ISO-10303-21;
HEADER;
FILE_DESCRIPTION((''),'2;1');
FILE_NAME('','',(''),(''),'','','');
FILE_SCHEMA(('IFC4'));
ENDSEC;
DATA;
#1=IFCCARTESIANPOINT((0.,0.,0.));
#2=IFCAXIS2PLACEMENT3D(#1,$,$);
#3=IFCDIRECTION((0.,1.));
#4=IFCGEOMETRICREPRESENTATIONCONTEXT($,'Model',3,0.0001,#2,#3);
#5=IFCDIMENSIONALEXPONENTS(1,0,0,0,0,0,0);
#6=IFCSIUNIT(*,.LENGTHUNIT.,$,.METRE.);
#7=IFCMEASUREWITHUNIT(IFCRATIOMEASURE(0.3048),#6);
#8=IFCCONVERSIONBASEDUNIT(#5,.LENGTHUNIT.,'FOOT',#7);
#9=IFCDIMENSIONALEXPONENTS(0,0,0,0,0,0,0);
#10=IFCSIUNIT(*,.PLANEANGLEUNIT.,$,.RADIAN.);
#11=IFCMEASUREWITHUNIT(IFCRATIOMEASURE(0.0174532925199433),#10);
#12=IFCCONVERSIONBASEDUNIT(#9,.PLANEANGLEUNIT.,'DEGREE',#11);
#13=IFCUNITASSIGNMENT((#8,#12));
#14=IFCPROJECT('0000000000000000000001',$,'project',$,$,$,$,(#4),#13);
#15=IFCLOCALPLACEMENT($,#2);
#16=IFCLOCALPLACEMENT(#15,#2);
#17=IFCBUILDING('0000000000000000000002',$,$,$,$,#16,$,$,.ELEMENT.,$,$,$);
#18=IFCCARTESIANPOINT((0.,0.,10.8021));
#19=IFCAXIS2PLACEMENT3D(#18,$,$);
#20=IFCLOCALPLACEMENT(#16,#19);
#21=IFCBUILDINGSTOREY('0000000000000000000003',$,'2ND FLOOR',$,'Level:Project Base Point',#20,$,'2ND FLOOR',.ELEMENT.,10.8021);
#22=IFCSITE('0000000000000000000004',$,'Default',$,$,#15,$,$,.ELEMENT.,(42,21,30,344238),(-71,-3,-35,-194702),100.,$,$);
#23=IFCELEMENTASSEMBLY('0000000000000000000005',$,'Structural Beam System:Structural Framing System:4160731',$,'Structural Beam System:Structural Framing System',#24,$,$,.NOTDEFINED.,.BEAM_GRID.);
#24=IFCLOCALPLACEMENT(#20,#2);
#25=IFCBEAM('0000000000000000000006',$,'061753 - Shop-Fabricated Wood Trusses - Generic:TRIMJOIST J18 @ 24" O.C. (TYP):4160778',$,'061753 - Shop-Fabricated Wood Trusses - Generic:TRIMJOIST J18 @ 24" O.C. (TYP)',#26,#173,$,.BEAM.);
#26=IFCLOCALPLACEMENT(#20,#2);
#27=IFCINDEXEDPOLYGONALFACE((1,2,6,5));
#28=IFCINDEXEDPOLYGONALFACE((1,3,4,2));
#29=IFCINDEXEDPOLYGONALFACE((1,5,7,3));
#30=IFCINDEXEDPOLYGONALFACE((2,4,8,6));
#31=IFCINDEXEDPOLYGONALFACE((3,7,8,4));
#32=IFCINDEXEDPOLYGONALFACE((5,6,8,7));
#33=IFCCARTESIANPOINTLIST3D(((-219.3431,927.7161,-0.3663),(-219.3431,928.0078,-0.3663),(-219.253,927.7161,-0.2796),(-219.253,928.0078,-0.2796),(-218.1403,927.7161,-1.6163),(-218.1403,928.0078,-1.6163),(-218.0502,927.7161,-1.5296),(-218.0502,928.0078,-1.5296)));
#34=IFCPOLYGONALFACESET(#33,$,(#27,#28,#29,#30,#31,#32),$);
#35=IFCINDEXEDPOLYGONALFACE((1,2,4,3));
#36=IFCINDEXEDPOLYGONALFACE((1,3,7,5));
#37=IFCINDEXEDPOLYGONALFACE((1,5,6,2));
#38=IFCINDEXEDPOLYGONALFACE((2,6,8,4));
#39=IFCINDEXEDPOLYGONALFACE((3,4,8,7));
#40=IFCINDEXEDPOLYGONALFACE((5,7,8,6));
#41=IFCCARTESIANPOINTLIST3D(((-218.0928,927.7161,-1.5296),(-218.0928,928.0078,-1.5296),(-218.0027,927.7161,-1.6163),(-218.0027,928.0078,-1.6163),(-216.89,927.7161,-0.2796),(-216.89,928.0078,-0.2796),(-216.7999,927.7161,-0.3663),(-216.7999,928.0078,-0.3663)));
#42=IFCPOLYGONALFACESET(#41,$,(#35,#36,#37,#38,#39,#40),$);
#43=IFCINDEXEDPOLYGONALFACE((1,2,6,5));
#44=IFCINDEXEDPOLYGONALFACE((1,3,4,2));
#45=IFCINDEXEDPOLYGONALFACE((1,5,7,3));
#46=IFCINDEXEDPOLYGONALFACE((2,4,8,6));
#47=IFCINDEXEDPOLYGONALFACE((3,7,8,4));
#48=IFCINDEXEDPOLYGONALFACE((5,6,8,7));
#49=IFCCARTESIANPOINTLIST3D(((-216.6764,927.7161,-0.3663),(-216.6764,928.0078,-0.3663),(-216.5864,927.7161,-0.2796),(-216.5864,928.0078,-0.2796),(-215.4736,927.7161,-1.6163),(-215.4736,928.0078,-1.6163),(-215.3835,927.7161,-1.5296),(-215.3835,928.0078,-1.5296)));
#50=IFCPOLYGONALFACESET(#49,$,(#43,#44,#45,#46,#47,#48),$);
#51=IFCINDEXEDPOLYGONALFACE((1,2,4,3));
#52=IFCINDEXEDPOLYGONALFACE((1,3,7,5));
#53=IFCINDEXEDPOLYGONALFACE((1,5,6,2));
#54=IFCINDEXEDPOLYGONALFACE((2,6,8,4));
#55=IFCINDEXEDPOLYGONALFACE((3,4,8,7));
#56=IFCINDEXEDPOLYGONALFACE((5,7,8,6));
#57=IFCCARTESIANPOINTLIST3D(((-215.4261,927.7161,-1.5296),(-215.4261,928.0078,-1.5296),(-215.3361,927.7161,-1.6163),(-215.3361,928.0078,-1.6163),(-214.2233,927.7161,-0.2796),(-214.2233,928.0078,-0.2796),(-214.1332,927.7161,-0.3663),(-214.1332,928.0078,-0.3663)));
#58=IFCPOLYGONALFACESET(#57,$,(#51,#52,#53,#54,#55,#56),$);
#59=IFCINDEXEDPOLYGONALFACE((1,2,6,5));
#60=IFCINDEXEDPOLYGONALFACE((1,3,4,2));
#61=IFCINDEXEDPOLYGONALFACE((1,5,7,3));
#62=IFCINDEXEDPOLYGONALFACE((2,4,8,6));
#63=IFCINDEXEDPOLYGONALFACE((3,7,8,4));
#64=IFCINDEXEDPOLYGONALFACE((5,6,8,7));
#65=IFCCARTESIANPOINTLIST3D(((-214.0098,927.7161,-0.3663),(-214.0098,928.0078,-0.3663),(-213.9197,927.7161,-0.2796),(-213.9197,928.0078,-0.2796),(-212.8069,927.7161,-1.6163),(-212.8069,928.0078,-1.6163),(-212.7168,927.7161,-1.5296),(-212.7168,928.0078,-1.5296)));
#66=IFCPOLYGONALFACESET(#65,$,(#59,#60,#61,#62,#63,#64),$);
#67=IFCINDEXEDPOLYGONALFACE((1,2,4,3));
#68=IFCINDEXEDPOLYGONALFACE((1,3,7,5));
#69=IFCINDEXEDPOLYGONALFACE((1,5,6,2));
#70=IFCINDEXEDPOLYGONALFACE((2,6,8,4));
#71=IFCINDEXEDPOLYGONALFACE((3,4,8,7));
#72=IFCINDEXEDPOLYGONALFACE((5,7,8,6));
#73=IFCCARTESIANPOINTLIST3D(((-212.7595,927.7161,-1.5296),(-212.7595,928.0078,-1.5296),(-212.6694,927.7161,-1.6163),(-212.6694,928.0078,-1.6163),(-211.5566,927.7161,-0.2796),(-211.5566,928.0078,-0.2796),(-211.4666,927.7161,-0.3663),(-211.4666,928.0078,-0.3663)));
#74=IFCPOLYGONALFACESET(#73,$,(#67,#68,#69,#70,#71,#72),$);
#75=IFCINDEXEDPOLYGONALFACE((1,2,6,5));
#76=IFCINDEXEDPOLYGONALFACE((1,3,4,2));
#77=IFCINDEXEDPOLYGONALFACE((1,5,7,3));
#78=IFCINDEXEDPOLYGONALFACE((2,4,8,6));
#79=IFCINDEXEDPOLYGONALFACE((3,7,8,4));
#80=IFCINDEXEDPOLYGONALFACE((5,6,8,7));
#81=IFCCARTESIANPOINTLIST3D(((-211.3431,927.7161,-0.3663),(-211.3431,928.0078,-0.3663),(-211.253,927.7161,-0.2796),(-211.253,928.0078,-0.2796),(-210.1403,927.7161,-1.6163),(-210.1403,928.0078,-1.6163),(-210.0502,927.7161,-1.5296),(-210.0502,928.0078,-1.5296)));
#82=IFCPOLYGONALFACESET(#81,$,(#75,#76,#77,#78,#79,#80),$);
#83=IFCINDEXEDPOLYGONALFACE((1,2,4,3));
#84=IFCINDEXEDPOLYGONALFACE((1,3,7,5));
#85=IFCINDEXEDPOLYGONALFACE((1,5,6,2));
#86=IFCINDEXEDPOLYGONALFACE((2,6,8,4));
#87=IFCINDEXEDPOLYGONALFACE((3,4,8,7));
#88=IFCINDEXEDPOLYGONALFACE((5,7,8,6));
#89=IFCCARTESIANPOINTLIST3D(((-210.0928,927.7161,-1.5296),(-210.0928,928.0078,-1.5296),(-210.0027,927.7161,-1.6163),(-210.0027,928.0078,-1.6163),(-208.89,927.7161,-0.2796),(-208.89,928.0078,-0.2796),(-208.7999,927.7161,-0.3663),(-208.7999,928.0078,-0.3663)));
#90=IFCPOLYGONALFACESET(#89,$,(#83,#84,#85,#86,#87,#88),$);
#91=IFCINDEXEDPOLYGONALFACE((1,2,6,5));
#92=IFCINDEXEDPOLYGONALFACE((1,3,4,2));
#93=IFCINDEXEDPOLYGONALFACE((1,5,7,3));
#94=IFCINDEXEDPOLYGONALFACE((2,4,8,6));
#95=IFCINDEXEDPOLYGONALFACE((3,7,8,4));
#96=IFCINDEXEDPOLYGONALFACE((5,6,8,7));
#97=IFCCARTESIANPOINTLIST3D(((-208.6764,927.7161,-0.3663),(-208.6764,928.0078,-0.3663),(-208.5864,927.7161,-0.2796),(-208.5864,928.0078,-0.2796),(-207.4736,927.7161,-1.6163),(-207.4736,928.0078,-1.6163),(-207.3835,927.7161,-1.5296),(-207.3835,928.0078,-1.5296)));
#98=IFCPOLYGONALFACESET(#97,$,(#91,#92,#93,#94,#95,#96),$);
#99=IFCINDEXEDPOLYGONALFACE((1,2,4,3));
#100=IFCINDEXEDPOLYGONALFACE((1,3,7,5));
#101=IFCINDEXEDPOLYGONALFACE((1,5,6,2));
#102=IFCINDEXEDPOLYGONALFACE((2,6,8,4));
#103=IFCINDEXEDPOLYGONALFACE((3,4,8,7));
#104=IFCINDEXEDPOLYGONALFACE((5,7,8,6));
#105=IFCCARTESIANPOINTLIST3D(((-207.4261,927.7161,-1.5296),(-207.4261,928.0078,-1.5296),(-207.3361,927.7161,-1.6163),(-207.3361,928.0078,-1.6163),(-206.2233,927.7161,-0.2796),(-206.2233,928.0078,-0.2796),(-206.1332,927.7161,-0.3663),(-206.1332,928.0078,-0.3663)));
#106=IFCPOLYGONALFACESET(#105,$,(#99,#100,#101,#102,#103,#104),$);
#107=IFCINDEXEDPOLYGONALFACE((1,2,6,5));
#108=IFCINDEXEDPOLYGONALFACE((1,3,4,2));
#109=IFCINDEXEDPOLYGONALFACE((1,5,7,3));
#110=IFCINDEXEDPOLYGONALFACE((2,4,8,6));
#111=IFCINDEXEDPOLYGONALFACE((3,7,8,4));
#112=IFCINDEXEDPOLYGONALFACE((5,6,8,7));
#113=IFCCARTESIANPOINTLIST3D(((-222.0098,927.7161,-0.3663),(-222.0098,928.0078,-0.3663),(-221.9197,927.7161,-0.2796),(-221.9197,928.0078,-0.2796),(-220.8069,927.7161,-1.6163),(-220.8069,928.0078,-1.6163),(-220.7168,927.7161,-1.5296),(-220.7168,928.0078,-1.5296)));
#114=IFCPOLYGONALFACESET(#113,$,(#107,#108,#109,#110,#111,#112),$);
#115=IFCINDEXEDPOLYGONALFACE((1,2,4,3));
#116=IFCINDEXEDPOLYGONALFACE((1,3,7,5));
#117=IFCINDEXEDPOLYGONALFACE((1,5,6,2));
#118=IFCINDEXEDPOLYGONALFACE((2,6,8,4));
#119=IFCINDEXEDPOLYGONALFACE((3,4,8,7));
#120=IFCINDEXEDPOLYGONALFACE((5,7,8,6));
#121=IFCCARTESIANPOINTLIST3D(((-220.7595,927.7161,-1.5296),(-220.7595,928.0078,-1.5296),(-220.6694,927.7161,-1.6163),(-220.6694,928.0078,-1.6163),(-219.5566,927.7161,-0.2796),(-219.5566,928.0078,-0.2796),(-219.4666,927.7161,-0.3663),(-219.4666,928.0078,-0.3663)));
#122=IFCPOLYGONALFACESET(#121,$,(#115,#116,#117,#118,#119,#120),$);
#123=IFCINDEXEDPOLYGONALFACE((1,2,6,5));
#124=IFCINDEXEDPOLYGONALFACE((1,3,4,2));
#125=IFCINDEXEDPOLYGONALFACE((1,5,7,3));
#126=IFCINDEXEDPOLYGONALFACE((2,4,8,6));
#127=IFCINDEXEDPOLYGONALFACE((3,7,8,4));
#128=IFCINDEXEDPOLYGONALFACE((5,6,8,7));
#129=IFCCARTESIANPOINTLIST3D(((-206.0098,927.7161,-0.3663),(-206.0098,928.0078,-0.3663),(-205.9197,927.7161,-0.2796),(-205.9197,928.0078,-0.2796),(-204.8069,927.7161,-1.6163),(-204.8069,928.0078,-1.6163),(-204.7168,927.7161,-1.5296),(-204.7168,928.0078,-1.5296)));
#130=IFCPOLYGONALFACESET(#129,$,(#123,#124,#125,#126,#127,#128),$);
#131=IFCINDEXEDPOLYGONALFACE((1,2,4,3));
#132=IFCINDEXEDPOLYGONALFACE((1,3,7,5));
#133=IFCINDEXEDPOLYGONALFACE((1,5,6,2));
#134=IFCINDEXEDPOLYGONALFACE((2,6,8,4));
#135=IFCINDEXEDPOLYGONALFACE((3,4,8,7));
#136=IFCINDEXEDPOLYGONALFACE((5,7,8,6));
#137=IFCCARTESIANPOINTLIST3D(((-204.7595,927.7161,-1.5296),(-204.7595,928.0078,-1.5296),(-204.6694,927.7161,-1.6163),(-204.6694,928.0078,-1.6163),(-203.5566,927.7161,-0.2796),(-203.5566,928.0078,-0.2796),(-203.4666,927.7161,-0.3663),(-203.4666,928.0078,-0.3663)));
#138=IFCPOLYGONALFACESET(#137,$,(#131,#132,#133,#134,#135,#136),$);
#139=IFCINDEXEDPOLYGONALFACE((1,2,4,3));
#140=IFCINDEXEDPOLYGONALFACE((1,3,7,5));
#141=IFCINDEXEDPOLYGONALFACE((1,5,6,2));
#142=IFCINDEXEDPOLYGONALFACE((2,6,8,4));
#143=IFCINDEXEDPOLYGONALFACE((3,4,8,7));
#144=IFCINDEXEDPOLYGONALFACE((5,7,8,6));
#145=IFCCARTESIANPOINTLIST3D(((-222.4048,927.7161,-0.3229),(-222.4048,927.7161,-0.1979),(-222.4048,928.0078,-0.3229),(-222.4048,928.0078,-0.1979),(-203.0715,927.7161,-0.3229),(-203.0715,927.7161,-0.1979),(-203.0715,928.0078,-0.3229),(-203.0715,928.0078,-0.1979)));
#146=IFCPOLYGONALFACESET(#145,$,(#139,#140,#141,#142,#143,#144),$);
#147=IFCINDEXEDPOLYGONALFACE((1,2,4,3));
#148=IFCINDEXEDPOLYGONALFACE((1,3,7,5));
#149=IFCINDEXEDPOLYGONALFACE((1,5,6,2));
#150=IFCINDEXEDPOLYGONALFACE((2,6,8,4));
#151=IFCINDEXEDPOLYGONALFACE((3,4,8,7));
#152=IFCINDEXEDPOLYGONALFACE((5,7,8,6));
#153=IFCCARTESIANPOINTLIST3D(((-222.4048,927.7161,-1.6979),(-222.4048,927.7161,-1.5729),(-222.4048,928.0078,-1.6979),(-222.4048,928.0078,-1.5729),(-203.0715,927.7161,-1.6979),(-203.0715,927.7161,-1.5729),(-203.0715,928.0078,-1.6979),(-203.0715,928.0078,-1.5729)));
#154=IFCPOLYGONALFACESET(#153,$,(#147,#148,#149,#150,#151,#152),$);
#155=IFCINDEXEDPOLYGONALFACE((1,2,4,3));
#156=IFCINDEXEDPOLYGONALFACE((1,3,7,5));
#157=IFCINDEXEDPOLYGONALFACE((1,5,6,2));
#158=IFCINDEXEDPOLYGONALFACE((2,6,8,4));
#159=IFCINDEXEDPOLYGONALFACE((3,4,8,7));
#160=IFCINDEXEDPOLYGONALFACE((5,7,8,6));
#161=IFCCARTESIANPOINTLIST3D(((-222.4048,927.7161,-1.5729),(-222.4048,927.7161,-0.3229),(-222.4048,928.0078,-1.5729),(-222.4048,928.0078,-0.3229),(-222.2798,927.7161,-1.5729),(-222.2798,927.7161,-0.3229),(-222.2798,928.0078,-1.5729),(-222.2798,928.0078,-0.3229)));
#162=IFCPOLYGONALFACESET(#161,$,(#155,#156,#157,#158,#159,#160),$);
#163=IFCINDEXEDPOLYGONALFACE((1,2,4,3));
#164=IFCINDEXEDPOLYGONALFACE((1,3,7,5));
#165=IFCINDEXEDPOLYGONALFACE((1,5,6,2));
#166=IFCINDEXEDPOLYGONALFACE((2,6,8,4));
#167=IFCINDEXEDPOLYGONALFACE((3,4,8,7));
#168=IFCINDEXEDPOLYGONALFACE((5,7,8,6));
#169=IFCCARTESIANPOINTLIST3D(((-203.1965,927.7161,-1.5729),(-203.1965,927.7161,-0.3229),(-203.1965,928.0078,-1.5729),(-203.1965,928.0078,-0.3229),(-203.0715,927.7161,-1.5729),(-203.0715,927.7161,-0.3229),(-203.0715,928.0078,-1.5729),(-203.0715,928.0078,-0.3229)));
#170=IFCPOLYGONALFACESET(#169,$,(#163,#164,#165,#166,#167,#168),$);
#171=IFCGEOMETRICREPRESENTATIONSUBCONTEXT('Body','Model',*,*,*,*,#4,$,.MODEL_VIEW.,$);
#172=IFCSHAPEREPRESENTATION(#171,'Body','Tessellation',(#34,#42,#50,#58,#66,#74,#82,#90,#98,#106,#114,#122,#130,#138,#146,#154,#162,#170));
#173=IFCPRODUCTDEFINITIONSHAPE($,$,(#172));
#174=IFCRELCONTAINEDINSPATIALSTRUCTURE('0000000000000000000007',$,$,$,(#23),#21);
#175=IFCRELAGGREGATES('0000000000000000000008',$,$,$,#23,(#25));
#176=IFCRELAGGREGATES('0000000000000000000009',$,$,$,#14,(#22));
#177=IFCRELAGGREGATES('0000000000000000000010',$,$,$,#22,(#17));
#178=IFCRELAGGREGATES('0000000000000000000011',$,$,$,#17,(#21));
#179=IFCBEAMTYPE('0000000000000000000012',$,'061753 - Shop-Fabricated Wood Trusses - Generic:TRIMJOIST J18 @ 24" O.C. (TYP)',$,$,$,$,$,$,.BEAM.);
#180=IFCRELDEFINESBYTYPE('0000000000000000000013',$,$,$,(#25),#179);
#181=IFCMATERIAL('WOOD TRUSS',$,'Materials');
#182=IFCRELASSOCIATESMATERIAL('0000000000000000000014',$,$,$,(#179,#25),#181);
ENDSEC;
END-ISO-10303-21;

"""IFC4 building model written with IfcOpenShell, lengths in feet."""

from ifc_helpers import new_model, entity, si_unit, converted_unit, direction, frame, frame_2d, origin, origin_2d_with_axis, place, context, subcontext, project, spatial, rectangle, extrude, source, transform, mapped, material, material_profile, profile_set, profile_usage, type_object, type_shapes, element, aggregate, save


model = new_model("IFC4")

# Units and contexts
model_context = context("Model", 3, precision=0.0001, world=origin(), true_north=direction((0.0, 1.0)))
body_context = subcontext(model_context, "Body", "Model", "MODEL_VIEW")
ifc_project = project(units=[converted_unit("LENGTHUNIT", "FOOT", entity("IfcRatioMeasure", 0.3048), si_unit("LENGTHUNIT", "METRE"), dimensions=[1, 0, 0, 0, 0, 0, 0]), converted_unit("PLANEANGLEUNIT", "DEGREE", entity("IfcRatioMeasure", 0.0174532925199433), si_unit("PLANEANGLEUNIT", "RADIAN"), dimensions=[0, 0, 0, 0, 0, 0, 0])], contexts=[model_context])

# Site, building, storey
site_placement = place(None, origin())
site = spatial("IfcSite", under=ifc_project, at=site_placement, Name="Default", CompositionType="ELEMENT", RefLatitude=(42, 21, 30, 344238), RefLongitude=(-71, -3, -35, -194702), RefElevation=100.0)
building_placement = place(site_placement, origin())
building = spatial("IfcBuilding", under=site, at=building_placement, CompositionType="ELEMENT")
storey_placement = place(building_placement, frame((0.0, 0.0, 10.8021)))
storey = spatial("IfcBuildingStorey", under=building, at=storey_placement, Name="2ND FLOOR", ObjectType="Level:Project Base Point", LongName="2ND FLOOR", CompositionType="ELEMENT", Elevation=10.8021)

# Element assembly, beam
ifc_material_1 = material(Name="WOOD TRUSS", Category="Materials")
ifc_material_profile_1 = material_profile(ifc_material_1, rectangle(XDim=1.7347, YDim=0.125, at=frame_2d((0.0, 0.0), x_axis=(1.0, 0.0))), Name="TRIMJOIST J18 @ 24\" O.C. (TYP)")
ifc_material_profile_2 = material_profile(ifc_material_1, rectangle(XDim=1.7347, YDim=0.125, at=frame_2d((0.0, 0.0), x_axis=(1.0, 0.0))), Name="TRIMJOIST J18 @ 24\" O.C. (TYP)")
ifc_material_profile_3 = material_profile(ifc_material_1, rectangle(XDim=1.7347, YDim=0.125, at=frame_2d((0.0, 0.0), x_axis=(1.0, 0.0))), Name="TRIMJOIST J18 @ 24\" O.C. (TYP)")
ifc_material_profile_4 = material_profile(ifc_material_1, rectangle(XDim=1.7347, YDim=0.125, at=frame_2d((0.0, 0.0), x_axis=(1.0, 0.0))), Name="TRIMJOIST J18 @ 24\" O.C. (TYP)")
ifc_material_profile_5 = material_profile(ifc_material_1, rectangle(XDim=1.7347, YDim=0.125, at=frame_2d((0.0, 0.0), x_axis=(1.0, 0.0))), Name="TRIMJOIST J18 @ 24\" O.C. (TYP)")
ifc_material_profile_6 = material_profile(ifc_material_1, rectangle(XDim=1.7347, YDim=0.125, at=frame_2d((0.0, 0.0), x_axis=(1.0, 0.0))), Name="TRIMJOIST J18 @ 24\" O.C. (TYP)")
ifc_material_profile_7 = material_profile(ifc_material_1, rectangle(XDim=1.7347, YDim=0.125, at=frame_2d((0.0, 0.0), x_axis=(1.0, 0.0))), Name="TRIMJOIST J18 @ 24\" O.C. (TYP)")
ifc_material_profile_8 = material_profile(ifc_material_1, rectangle(XDim=1.7347, YDim=0.125, at=frame_2d((0.0, 0.0), x_axis=(1.0, 0.0))), Name="TRIMJOIST J18 @ 24\" O.C. (TYP)")
ifc_material_profile_9 = material_profile(ifc_material_1, rectangle(XDim=1.7347, YDim=0.125, at=frame_2d((0.0, 0.0), x_axis=(1.0, 0.0))), Name="TRIMJOIST J18 @ 24\" O.C. (TYP)")
ifc_material_profile_10 = material_profile(ifc_material_1, rectangle(XDim=1.7347, YDim=0.125, at=origin_2d_with_axis()), Name="TRIMJOIST J18 @ 24\" O.C. (TYP)")
ifc_material_profile_11 = material_profile(ifc_material_1, rectangle(XDim=0.125, YDim=0.2917, at=origin_2d_with_axis()), Name="TRIMJOIST J18 @ 24\" O.C. (TYP)")
ifc_material_profile_12 = material_profile(ifc_material_1, rectangle(XDim=0.125, YDim=0.2917, at=origin_2d_with_axis()), Name="TRIMJOIST J18 @ 24\" O.C. (TYP)")
ifc_material_profile_13 = material_profile(ifc_material_1, rectangle(XDim=1.25, YDim=0.2917, at=origin_2d_with_axis()), Name="TRIMJOIST J18 @ 24\" O.C. (TYP)")
ifc_material_profile_14 = material_profile(ifc_material_1, rectangle(XDim=1.25, YDim=0.2917, at=origin_2d_with_axis()), Name="TRIMJOIST J18 @ 24\" O.C. (TYP)")
ifc_profile_set_1 = profile_set([ifc_material_profile_1, ifc_material_profile_2, ifc_material_profile_3, ifc_material_profile_4, ifc_material_profile_5, ifc_material_profile_6, ifc_material_profile_7, ifc_material_profile_8, ifc_material_profile_9, ifc_material_profile_10, ifc_material_profile_11, ifc_material_profile_12, ifc_material_profile_13, ifc_material_profile_14], Name="TRIMJOIST J18 @ 24\" O.C. (TYP)")
beam_type_1 = type_object("IfcBeamType", Name="061753 - Shop-Fabricated Wood Trusses - Generic:TRIMJOIST J18 @ 24\" O.C. (TYP)", PredefinedType="BEAM", material=ifc_profile_set_1)
shared_shape_1 = source(origin(), body_context, "Body", "SweptSolid", [
    extrude(rectangle(XDim=1.7347, YDim=0.125, at=frame_2d((0.0, 0.0), x_axis=(1.0, 0.0))), frame((5.9585, -0.1458, 0.0), z_axis=(0.0, 1.0, 0.0), x_axis=(0.693383, 0.0, 0.720569)), (0.0, 0.0, 1.0), 0.2917),
    extrude(rectangle(XDim=1.7347, YDim=0.125, at=origin_2d_with_axis()), frame((4.7082, -0.1458, 0.0), z_axis=(0.0, 1.0, 0.0), x_axis=(0.693383, 0.0, -0.720569)), (0.0, 0.0, 1.0), 0.2917),
    extrude(rectangle(XDim=1.7347, YDim=0.125, at=frame_2d((0.0, 0.0), x_axis=(1.0, 0.0))), frame((3.2918, -0.1458, 0.0), z_axis=(0.0, 1.0, 0.0), x_axis=(0.693383, 0.0, 0.720569)), (0.0, 0.0, 1.0), 0.2917),
    extrude(rectangle(XDim=1.7347, YDim=0.125, at=frame_2d((0.0, 0.0), x_axis=(1.0, 0.0))), frame((2.0415, -0.1458, 0.0), z_axis=(0.0, 1.0, 0.0), x_axis=(0.693383, 0.0, -0.720569)), (0.0, 0.0, 1.0), 0.2917),
    extrude(rectangle(XDim=1.7347, YDim=0.125, at=frame_2d((0.0, 0.0), x_axis=(1.0, 0.0))), frame((0.6251, -0.1458, 0.0), z_axis=(0.0, 1.0, 0.0), x_axis=(0.693383, 0.0, 0.720569)), (0.0, 0.0, 1.0), 0.2917),
    extrude(rectangle(XDim=1.7347, YDim=0.125, at=frame_2d((0.0, 0.0), x_axis=(1.0, 0.0))), frame((-0.6251, -0.1458, 0.0), z_axis=(0.0, 1.0, 0.0), x_axis=(0.693383, 0.0, -0.720569)), (0.0, 0.0, 1.0), 0.2917),
    extrude(rectangle(XDim=1.7347, YDim=0.125, at=frame_2d((0.0, 0.0), x_axis=(1.0, 0.0))), frame((-2.0415, -0.1458, 0.0), z_axis=(0.0, 1.0, 0.0), x_axis=(0.693383, 0.0, 0.720569)), (0.0, 0.0, 1.0), 0.2917),
    extrude(rectangle(XDim=1.7347, YDim=0.125, at=origin_2d_with_axis()), frame((-3.2918, -0.1458, 0.0), z_axis=(0.0, 1.0, 0.0), x_axis=(0.693383, 0.0, -0.720569)), (0.0, 0.0, 1.0), 0.2917),
    extrude(rectangle(XDim=1.7347, YDim=0.125, at=frame_2d((0.0, 0.0), x_axis=(1.0, 0.0))), frame((-4.7082, -0.1458, 0.0), z_axis=(0.0, 1.0, 0.0), x_axis=(0.693383, 0.0, 0.720569)), (0.0, 0.0, 1.0), 0.2917),
    extrude(rectangle(XDim=1.7347, YDim=0.125, at=frame_2d((0.0, 0.0), x_axis=(1.0, 0.0))), frame((-5.9585, -0.1458, 0.0), z_axis=(0.0, 1.0, 0.0), x_axis=(0.693383, 0.0, -0.720569)), (0.0, 0.0, 1.0), 0.2917),
    extrude(rectangle(XDim=1.7347, YDim=0.125, at=frame_2d((0.0, 0.0), x_axis=(1.0, 0.0))), frame((8.6251, -0.1458, 0.0), z_axis=(0.0, 1.0, 0.0), x_axis=(0.693383, 0.0, 0.720569)), (0.0, 0.0, 1.0), 0.2917),
    extrude(rectangle(XDim=1.7347, YDim=0.125, at=origin_2d_with_axis()), frame((7.3749, -0.1458, 0.0), z_axis=(0.0, 1.0, 0.0), x_axis=(0.693383, 0.0, -0.720569)), (0.0, 0.0, 1.0), 0.2917),
    extrude(rectangle(XDim=1.7347, YDim=0.125, at=frame_2d((0.0, 0.0), x_axis=(1.0, 0.0))), frame((-7.3749, -0.1458, 0.0), z_axis=(0.0, 1.0, 0.0), x_axis=(0.693383, 0.0, 0.720569)), (0.0, 0.0, 1.0), 0.2917),
    extrude(rectangle(XDim=1.7347, YDim=0.125, at=origin_2d_with_axis()), frame((-8.6251, -0.1458, 0.0), z_axis=(0.0, 1.0, 0.0), x_axis=(0.693383, 0.0, -0.720569)), (0.0, 0.0, 1.0), 0.2917),
    extrude(rectangle(XDim=0.125, YDim=0.2917, at=origin_2d_with_axis()), frame((-9.6667, 0.0, 0.6875), z_axis=(1.0, 0.0, 0.0), x_axis=(0.0, 0.0, -1.0)), (0.0, 0.0, 1.0), 19.3333),
    extrude(rectangle(XDim=0.125, YDim=0.2917, at=origin_2d_with_axis()), frame((-9.6667, 0.0, -0.6875), z_axis=(1.0, 0.0, 0.0), x_axis=(0.0, 0.0, -1.0)), (0.0, 0.0, 1.0), 19.3333),
    extrude(rectangle(XDim=1.25, YDim=0.2917, at=origin_2d_with_axis()), frame((9.5417, 0.0, 0.0), z_axis=(1.0, 0.0, 0.0), x_axis=(0.0, 0.0, -1.0)), (0.0, 0.0, 1.0), 0.125),
    extrude(rectangle(XDim=1.25, YDim=0.2917, at=origin_2d_with_axis()), frame((-9.6667, 0.0, 0.0), z_axis=(1.0, 0.0, 0.0), x_axis=(0.0, 0.0, -1.0)), (0.0, 0.0, 1.0), 0.125),
])
type_shapes(beam_type_1, [shared_shape_1])
assembly_1_placement = place(storey_placement, origin())
assembly_1 = element("IfcElementAssembly", 1, at=assembly_1_placement, inside=storey, Name="Structural Beam System:Structural Framing System:4160731", ObjectType="Structural Beam System:Structural Framing System", AssemblyPlace="NOTDEFINED", PredefinedType="BEAM_GRID")
ifc_profile_usage_1 = profile_usage(ifc_profile_set_1, cardinal=8)
beam_1_placement = place(assembly_1_placement, frame((-212.7382, 927.8619, -0.9479), z_axis=(0.0, 0.0, 1.0), x_axis=(-1.0, 0.0, 0.0)))
beam_1 = element("IfcBeam", 2, at=beam_1_placement, type_object=beam_type_1, material=ifc_profile_usage_1, Name="061753 - Shop-Fabricated Wood Trusses - Generic:TRIMJOIST J18 @ 24\" O.C. (TYP):4160778", ObjectType="061753 - Shop-Fabricated Wood Trusses - Generic:TRIMJOIST J18 @ 24\" O.C. (TYP)", PredefinedType="BEAM", context=body_context, shape_type="MappedRepresentation", body=[
    mapped(shared_shape_1, transform((0.0, 0.0, 0.0), scale=1.0)),
])
aggregate(assembly_1, [beam_1])

save(model, "model.ifc")
